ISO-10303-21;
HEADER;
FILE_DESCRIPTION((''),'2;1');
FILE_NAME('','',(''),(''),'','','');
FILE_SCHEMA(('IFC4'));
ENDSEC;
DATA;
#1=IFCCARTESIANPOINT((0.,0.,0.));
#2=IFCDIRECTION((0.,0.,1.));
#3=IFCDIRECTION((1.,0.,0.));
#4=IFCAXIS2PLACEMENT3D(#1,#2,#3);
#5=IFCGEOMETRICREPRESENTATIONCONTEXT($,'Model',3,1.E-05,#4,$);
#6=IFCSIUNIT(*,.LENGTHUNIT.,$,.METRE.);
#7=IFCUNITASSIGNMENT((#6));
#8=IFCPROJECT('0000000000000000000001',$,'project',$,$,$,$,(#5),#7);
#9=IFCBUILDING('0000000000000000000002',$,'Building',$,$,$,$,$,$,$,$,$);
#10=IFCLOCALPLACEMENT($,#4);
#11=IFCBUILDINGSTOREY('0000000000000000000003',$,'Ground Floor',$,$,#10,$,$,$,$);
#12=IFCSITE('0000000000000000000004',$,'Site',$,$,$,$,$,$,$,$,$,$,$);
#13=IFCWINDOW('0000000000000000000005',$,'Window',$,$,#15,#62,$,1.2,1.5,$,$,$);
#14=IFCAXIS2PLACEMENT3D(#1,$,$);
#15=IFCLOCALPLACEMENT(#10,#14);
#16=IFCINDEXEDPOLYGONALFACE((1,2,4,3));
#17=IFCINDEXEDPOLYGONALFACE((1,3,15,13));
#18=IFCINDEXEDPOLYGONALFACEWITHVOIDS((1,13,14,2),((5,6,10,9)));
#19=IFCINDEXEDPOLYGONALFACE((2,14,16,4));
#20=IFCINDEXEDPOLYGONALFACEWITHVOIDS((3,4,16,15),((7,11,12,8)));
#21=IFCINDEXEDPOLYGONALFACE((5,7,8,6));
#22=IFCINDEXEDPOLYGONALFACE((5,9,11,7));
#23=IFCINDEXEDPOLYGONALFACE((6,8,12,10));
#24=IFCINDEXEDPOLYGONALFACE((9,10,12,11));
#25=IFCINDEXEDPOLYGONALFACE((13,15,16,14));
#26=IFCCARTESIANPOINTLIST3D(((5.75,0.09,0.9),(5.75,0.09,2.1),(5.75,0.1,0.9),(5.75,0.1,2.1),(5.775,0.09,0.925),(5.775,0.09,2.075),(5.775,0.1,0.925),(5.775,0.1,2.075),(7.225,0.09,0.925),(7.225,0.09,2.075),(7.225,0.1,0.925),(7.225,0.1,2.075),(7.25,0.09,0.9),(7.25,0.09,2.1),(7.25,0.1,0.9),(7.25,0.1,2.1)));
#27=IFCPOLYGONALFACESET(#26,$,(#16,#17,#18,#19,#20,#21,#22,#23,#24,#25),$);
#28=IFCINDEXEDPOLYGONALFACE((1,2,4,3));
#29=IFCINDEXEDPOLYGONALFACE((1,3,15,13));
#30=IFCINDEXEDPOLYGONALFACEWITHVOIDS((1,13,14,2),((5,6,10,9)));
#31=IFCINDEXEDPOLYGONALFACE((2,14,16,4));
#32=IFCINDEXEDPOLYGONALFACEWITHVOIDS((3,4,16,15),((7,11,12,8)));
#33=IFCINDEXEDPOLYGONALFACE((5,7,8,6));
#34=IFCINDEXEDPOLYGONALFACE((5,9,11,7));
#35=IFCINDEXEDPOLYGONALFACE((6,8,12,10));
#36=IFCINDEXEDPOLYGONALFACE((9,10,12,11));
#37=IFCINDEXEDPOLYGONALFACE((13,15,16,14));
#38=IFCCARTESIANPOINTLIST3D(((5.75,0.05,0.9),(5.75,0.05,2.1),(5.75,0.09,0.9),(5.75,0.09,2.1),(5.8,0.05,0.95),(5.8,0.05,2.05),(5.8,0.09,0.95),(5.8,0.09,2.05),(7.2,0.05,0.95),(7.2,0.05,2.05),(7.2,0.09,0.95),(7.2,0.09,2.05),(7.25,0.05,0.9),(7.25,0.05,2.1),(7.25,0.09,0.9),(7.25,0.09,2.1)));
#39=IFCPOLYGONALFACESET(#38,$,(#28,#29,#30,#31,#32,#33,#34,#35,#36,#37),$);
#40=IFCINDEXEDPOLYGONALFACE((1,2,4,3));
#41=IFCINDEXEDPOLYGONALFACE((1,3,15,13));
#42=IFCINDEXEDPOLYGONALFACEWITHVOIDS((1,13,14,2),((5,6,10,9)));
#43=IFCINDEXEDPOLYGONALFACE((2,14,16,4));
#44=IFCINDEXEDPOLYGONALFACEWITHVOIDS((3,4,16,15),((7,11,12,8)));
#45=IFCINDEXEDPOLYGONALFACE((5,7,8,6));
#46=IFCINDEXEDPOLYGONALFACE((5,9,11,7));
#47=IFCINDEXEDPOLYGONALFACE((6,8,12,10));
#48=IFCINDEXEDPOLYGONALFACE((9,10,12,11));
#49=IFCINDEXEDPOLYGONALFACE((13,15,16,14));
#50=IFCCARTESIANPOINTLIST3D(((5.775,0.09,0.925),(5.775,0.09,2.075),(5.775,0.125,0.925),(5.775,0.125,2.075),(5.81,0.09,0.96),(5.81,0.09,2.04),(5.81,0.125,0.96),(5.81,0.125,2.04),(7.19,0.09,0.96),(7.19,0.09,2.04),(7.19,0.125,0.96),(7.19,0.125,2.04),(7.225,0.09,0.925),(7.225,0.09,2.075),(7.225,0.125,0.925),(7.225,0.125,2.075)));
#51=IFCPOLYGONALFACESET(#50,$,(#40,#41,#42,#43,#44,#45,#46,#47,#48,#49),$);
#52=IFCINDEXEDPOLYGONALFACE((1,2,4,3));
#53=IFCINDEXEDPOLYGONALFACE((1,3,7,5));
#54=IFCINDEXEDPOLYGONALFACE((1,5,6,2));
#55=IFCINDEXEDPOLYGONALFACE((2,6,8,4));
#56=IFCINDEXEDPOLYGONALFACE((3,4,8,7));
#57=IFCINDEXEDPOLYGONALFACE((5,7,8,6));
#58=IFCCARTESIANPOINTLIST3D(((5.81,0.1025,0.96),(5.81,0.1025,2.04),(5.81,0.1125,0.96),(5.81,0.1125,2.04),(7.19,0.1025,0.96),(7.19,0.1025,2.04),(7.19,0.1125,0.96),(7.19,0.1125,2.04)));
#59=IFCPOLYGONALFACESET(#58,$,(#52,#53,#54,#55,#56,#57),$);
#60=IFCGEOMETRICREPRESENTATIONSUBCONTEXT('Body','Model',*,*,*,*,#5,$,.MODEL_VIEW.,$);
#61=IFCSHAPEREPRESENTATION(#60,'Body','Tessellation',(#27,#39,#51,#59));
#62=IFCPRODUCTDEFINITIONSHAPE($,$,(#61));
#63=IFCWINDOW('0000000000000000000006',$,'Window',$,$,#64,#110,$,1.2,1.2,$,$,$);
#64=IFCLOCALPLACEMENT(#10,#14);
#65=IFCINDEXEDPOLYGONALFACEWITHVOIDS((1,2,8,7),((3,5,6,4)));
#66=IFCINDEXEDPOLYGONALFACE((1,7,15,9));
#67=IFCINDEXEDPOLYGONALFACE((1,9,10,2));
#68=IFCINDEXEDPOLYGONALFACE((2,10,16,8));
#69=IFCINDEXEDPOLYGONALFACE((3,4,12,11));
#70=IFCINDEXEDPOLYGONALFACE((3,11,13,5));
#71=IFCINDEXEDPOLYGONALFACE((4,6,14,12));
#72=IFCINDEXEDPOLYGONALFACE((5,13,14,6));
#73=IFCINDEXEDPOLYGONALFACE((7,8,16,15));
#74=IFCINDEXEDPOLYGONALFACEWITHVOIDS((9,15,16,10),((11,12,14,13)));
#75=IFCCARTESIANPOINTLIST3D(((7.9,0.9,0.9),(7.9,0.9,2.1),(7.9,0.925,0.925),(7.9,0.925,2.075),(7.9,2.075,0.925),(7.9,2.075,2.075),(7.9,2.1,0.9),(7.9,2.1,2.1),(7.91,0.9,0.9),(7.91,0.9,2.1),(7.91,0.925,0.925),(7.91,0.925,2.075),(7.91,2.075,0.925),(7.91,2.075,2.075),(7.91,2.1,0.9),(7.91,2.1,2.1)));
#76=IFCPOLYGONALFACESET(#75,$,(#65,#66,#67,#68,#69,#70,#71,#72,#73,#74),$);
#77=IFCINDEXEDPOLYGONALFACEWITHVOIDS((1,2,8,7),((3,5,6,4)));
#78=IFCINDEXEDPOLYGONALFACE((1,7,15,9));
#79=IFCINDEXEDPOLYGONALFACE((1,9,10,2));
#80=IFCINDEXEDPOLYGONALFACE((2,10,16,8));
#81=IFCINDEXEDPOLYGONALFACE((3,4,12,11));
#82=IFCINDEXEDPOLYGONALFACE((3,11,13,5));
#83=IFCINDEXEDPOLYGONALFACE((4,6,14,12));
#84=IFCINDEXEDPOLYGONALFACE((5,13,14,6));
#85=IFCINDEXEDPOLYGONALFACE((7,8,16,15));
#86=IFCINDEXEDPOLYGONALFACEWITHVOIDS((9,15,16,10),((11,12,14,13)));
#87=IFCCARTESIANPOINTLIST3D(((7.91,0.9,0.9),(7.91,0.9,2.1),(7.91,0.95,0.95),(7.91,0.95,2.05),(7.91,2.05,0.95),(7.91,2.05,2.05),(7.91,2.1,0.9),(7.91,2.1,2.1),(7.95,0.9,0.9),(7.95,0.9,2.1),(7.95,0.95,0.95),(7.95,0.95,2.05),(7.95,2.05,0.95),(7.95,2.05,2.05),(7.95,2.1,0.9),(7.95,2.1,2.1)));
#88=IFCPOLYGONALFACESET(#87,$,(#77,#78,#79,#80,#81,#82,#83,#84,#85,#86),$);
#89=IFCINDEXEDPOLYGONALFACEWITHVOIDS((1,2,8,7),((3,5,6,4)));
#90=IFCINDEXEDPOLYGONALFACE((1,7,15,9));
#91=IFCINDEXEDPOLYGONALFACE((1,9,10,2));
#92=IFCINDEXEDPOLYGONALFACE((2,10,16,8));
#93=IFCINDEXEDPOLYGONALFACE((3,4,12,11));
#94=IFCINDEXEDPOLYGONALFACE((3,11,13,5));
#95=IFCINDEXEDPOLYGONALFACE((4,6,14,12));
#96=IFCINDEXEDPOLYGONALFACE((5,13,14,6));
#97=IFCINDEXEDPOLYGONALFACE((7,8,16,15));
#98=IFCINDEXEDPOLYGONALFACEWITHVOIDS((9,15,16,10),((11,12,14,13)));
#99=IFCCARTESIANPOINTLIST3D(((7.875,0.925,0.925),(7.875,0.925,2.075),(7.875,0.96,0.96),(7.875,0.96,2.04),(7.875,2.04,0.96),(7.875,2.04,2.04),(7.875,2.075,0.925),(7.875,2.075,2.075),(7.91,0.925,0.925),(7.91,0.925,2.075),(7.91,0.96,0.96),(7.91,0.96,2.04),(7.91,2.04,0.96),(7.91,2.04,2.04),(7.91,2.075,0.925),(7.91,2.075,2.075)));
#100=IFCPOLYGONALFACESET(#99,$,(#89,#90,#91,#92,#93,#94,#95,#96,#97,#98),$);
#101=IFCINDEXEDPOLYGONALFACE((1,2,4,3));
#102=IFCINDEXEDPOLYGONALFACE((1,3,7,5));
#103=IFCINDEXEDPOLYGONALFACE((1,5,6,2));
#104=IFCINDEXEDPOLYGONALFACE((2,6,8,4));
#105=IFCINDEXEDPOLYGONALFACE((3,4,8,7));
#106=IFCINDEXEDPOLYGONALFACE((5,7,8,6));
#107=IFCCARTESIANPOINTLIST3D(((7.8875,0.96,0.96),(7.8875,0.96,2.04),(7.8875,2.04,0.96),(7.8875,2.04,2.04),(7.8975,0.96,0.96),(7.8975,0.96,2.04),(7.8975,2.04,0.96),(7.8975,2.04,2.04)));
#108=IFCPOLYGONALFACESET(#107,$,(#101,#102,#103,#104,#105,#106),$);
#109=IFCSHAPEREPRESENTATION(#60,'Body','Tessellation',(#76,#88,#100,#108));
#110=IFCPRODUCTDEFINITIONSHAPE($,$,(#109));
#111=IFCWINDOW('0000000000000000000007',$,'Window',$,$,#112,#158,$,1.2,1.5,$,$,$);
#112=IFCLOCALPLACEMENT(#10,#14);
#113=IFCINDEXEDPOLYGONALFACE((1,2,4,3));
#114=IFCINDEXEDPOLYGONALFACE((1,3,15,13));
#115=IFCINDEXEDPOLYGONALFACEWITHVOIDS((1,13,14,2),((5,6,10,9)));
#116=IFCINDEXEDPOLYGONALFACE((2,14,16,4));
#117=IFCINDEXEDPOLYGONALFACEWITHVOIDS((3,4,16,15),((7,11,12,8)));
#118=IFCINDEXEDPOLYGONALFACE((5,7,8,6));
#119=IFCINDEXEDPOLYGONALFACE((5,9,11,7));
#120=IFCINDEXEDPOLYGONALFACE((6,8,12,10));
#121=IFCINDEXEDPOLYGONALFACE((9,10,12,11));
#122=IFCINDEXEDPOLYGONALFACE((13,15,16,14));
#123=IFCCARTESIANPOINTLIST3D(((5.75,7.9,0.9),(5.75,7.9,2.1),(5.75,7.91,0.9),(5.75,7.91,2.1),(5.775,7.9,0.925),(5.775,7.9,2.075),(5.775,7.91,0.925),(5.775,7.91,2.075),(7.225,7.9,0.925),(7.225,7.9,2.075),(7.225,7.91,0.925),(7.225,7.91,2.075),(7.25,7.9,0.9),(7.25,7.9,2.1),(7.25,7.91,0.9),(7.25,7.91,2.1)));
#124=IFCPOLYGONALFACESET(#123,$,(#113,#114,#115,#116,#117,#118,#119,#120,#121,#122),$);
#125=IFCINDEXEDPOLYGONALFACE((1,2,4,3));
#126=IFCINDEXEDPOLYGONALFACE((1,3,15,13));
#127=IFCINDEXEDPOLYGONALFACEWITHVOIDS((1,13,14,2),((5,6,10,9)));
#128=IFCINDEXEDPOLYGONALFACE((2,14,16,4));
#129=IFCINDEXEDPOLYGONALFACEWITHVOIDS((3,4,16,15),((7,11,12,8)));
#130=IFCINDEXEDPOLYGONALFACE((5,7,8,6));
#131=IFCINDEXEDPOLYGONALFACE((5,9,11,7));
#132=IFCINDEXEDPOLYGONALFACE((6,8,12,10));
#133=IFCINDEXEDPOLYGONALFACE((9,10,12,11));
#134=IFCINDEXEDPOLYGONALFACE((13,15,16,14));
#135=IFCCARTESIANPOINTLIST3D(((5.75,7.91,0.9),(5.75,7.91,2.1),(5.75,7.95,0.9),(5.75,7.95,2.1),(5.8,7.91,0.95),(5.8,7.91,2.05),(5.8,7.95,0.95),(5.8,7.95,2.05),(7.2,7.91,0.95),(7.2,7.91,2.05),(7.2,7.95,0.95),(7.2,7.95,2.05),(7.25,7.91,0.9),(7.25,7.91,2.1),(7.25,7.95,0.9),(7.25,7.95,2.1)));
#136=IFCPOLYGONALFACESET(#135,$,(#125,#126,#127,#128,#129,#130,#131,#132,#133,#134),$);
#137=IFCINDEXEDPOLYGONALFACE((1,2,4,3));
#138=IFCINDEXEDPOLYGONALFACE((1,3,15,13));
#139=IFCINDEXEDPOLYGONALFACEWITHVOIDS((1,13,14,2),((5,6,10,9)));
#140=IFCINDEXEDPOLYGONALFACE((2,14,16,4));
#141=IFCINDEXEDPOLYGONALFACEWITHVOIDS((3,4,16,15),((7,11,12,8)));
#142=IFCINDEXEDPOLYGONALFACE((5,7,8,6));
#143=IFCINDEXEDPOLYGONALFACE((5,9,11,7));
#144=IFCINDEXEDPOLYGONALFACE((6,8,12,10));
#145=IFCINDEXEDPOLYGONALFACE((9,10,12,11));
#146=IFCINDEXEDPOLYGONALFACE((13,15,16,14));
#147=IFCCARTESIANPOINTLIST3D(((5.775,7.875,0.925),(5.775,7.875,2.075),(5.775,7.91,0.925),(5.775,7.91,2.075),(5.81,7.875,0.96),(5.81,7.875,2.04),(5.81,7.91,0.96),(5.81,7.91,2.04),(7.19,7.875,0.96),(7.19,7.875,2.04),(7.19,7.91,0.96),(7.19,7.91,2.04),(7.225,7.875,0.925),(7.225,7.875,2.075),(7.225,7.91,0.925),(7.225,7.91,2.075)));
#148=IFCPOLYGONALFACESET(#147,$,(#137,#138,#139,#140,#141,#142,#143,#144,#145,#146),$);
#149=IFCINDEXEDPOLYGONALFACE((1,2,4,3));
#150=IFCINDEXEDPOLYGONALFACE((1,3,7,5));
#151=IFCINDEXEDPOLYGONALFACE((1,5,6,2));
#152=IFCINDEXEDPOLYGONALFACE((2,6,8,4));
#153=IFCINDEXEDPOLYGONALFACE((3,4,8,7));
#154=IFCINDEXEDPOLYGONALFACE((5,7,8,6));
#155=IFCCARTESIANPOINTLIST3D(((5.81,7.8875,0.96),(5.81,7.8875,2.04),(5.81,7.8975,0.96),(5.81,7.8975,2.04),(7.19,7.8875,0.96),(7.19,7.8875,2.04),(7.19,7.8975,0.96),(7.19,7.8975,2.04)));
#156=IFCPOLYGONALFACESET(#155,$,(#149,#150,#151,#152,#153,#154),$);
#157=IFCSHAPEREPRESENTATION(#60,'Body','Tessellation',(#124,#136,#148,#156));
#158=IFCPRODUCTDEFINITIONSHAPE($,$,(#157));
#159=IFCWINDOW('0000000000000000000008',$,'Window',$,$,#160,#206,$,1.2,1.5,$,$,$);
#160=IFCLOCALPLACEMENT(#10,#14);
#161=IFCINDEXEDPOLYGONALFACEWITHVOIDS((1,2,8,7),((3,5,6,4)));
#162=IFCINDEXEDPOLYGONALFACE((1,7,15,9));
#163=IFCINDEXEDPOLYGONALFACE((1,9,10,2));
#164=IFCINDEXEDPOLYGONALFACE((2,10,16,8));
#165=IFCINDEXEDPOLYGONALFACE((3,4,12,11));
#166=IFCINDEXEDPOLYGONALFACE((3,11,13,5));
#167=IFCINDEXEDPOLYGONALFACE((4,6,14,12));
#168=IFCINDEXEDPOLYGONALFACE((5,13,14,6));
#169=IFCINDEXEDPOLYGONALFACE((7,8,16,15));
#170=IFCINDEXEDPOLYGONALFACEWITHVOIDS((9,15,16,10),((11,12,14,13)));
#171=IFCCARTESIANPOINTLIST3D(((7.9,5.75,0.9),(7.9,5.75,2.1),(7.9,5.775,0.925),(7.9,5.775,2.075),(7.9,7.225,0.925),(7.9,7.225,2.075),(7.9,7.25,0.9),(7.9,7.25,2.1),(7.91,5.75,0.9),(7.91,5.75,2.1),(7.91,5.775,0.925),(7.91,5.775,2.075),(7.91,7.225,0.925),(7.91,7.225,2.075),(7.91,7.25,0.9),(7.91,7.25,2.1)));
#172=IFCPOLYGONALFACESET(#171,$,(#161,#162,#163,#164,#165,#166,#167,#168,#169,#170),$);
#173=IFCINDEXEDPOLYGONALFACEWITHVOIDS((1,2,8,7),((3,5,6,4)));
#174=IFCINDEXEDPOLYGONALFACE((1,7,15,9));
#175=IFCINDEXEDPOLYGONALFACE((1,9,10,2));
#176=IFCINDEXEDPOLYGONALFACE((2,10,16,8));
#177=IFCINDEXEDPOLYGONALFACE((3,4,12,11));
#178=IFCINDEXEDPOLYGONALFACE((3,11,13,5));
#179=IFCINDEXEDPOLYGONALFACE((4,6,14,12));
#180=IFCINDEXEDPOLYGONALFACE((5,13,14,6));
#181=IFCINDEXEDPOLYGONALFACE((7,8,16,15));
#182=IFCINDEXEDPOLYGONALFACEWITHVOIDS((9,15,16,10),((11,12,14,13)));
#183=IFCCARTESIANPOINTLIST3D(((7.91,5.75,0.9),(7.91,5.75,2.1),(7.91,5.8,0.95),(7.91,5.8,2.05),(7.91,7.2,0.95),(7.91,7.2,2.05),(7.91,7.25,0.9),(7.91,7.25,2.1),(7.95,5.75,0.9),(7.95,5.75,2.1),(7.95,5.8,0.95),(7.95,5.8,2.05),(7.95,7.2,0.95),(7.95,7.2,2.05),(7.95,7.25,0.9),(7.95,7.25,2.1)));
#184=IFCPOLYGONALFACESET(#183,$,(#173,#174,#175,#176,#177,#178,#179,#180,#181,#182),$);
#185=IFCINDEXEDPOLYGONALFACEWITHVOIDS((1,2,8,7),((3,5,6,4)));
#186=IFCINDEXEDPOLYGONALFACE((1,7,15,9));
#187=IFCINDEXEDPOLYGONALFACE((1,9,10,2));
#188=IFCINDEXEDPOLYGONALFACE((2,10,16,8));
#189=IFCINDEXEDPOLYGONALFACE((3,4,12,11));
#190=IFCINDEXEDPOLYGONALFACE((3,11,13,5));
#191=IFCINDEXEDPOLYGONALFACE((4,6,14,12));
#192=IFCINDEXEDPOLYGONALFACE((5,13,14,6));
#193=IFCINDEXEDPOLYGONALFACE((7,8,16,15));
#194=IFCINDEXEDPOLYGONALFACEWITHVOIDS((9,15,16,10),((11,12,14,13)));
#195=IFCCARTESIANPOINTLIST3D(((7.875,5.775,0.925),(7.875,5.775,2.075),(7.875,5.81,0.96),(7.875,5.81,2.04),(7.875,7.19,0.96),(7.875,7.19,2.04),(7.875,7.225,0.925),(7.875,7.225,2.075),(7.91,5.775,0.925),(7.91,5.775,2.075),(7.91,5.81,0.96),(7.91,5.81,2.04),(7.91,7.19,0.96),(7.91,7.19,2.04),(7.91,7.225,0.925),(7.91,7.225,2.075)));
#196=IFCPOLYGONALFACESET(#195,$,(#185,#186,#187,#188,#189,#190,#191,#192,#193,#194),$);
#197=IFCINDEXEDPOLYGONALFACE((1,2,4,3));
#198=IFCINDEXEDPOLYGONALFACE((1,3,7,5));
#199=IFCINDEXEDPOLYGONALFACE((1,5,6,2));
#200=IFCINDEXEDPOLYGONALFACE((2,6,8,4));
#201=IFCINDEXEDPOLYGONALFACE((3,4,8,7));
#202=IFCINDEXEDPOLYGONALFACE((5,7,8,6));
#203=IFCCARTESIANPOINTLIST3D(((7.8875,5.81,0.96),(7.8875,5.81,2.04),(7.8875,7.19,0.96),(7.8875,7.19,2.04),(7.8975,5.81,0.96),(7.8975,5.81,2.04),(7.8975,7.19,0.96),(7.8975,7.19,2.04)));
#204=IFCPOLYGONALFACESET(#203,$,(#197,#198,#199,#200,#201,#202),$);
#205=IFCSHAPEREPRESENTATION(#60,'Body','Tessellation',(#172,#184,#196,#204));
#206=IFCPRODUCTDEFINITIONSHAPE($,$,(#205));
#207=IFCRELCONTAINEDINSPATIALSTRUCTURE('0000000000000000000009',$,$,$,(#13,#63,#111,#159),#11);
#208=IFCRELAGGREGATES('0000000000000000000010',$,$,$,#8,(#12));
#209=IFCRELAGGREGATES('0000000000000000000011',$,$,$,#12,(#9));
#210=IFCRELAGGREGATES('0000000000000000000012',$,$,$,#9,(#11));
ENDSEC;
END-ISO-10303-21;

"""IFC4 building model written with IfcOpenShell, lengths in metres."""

from ifc_helpers import new_model, si_unit, frame, origin_with_axes, place, context, subcontext, project, spatial, line, indexed_curve, outline, extrude, element, save


model = new_model("IFC4")

# Units and contexts
model_context = context("Model", 3, precision=1e-05, world=origin_with_axes())
body_context = subcontext(model_context, "Body", "Model", "MODEL_VIEW")
ifc_project = project(units=[si_unit("LENGTHUNIT", "METRE")], contexts=[model_context])

# Site, building, storey
site = spatial("IfcSite", under=ifc_project, Name="Site")
building = spatial("IfcBuilding", under=site, Name="Building")
storey_placement = place(None, origin_with_axes())
storey = spatial("IfcBuildingStorey", under=building, at=storey_placement, Name="Ground Floor")

# Windows
window_1_placement = place(storey_placement, frame((5.75, 0.0, 0.9), z_axis=(0.0, 0.0, 1.0), x_axis=(1.0, 0.0, 0.0)))
element("IfcWindow", 1, at=window_1_placement, inside=storey, Name="Window", OverallHeight=1.2, OverallWidth=1.5, context=body_context, shape_type="SweptSolid", body=[
    extrude(outline(indexed_curve([(0.0, 0.0), (1.5, 0.0), (1.5, 1.2), (0.0, 1.2)], segments=[line(1, 2, 3, 4, 1)]), holes=[indexed_curve([(0.025, 0.025), (1.475, 0.025), (1.475, 1.175), (0.025, 1.175)], segments=[line(1, 2, 3, 4, 1)])]), frame((0.0, 0.09, 0.0), z_axis=(0.0, -1.0, 0.0), x_axis=(1.0, 0.0, 0.0)), (0.0, 0.0, -1.0), 0.01),
    extrude(outline(indexed_curve([(0.0, 0.0), (1.5, 0.0), (1.5, 1.2), (0.0, 1.2)], segments=[line(1, 2, 3, 4, 1)]), holes=[indexed_curve([(0.05, 0.05), (1.45, 0.05), (1.45, 1.15), (0.05, 1.15)], segments=[line(1, 2, 3, 4, 1)])]), frame((0.0, 0.05, 0.0), z_axis=(0.0, -1.0, 0.0), x_axis=(1.0, 0.0, 0.0)), (0.0, 0.0, -1.0), 0.04),
    extrude(outline(indexed_curve([(0.0, 0.0), (1.45, 0.0), (1.45, 1.15), (0.0, 1.15)], segments=[line(1, 2, 3, 4, 1)]), holes=[indexed_curve([(0.035, 0.035), (1.415, 0.035), (1.415, 1.115), (0.035, 1.115)], segments=[line(1, 2, 3, 4, 1)])]), frame((0.025, 0.09, 0.025), z_axis=(0.0, -1.0, 0.0), x_axis=(1.0, 0.0, 0.0)), (0.0, 0.0, -1.0), 0.035),
    extrude(outline(indexed_curve([(0.035, 0.035), (1.415, 0.035), (1.415, 1.115), (0.035, 1.115)], segments=[line(1, 2, 3, 4, 1)])), frame((0.025, 0.1025, 0.025), z_axis=(0.0, -1.0, 0.0), x_axis=(1.0, 0.0, 0.0)), (0.0, 0.0, -1.0), 0.01),
])
window_2_placement = place(storey_placement, frame((8.0, 0.9, 0.9), z_axis=(0.0, 0.0, 1.0), x_axis=(0.0, 1.0, 0.0)))
element("IfcWindow", 2, at=window_2_placement, inside=storey, Name="Window", OverallHeight=1.2, OverallWidth=1.2, context=body_context, shape_type="SweptSolid", body=[
    extrude(outline(indexed_curve([(0.0, 0.0), (1.2, 0.0), (1.2, 1.2), (0.0, 1.2)], segments=[line(1, 2, 3, 4, 1)]), holes=[indexed_curve([(0.025, 0.025), (1.175, 0.025), (1.175, 1.175), (0.025, 1.175)], segments=[line(1, 2, 3, 4, 1)])]), frame((0.0, 0.09, 0.0), z_axis=(0.0, -1.0, 0.0), x_axis=(1.0, 0.0, 0.0)), (0.0, 0.0, -1.0), 0.01),
    extrude(outline(indexed_curve([(0.0, 0.0), (1.2, 0.0), (1.2, 1.2), (0.0, 1.2)], segments=[line(1, 2, 3, 4, 1)]), holes=[indexed_curve([(0.05, 0.05), (1.15, 0.05), (1.15, 1.15), (0.05, 1.15)], segments=[line(1, 2, 3, 4, 1)])]), frame((0.0, 0.05, 0.0), z_axis=(0.0, -1.0, 0.0), x_axis=(1.0, 0.0, 0.0)), (0.0, 0.0, -1.0), 0.04),
    extrude(outline(indexed_curve([(0.0, 0.0), (1.15, 0.0), (1.15, 1.15), (0.0, 1.15)], segments=[line(1, 2, 3, 4, 1)]), holes=[indexed_curve([(0.035, 0.035), (1.115, 0.035), (1.115, 1.115), (0.035, 1.115)], segments=[line(1, 2, 3, 4, 1)])]), frame((0.025, 0.09, 0.025), z_axis=(0.0, -1.0, 0.0), x_axis=(1.0, 0.0, 0.0)), (0.0, 0.0, -1.0), 0.035),
    extrude(outline(indexed_curve([(0.035, 0.035), (1.115, 0.035), (1.115, 1.115), (0.035, 1.115)], segments=[line(1, 2, 3, 4, 1)])), frame((0.025, 0.1025, 0.025), z_axis=(0.0, -1.0, 0.0), x_axis=(1.0, 0.0, 0.0)), (0.0, 0.0, -1.0), 0.01),
])
for number, where, z_axis, x_axis, name in (
    (3, (7.25, 8.0, 0.9), (0.0, 0.0, 1.0), (-1.0, 0.0, 0.0), "Window"),
    (4, (8.0, 5.75, 0.9), (0.0, 0.0, 1.0), (0.0, 1.0, 0.0), "Window"),
):
    element("IfcWindow", number, at=place(storey_placement, frame(where, z_axis=z_axis, x_axis=x_axis)), inside=storey, Name=name, OverallHeight=1.2, OverallWidth=1.5, context=body_context, shape_type="SweptSolid", body=[
        extrude(outline(indexed_curve([(0.0, 0.0), (1.5, 0.0), (1.5, 1.2), (0.0, 1.2)], segments=[line(1, 2, 3, 4, 1)]), holes=[indexed_curve([(0.025, 0.025), (1.475, 0.025), (1.475, 1.175), (0.025, 1.175)], segments=[line(1, 2, 3, 4, 1)])]), frame((0.0, 0.09, 0.0), z_axis=(0.0, -1.0, 0.0), x_axis=(1.0, 0.0, 0.0)), (0.0, 0.0, -1.0), 0.01),
        extrude(outline(indexed_curve([(0.0, 0.0), (1.5, 0.0), (1.5, 1.2), (0.0, 1.2)], segments=[line(1, 2, 3, 4, 1)]), holes=[indexed_curve([(0.05, 0.05), (1.45, 0.05), (1.45, 1.15), (0.05, 1.15)], segments=[line(1, 2, 3, 4, 1)])]), frame((0.0, 0.05, 0.0), z_axis=(0.0, -1.0, 0.0), x_axis=(1.0, 0.0, 0.0)), (0.0, 0.0, -1.0), 0.04),
        extrude(outline(indexed_curve([(0.0, 0.0), (1.45, 0.0), (1.45, 1.15), (0.0, 1.15)], segments=[line(1, 2, 3, 4, 1)]), holes=[indexed_curve([(0.035, 0.035), (1.415, 0.035), (1.415, 1.115), (0.035, 1.115)], segments=[line(1, 2, 3, 4, 1)])]), frame((0.025, 0.09, 0.025), z_axis=(0.0, -1.0, 0.0), x_axis=(1.0, 0.0, 0.0)), (0.0, 0.0, -1.0), 0.035),
        extrude(outline(indexed_curve([(0.035, 0.035), (1.415, 0.035), (1.415, 1.115), (0.035, 1.115)], segments=[line(1, 2, 3, 4, 1)])), frame((0.025, 0.1025, 0.025), z_axis=(0.0, -1.0, 0.0), x_axis=(1.0, 0.0, 0.0)), (0.0, 0.0, -1.0), 0.01),
    ])

save(model, "model.ifc")
